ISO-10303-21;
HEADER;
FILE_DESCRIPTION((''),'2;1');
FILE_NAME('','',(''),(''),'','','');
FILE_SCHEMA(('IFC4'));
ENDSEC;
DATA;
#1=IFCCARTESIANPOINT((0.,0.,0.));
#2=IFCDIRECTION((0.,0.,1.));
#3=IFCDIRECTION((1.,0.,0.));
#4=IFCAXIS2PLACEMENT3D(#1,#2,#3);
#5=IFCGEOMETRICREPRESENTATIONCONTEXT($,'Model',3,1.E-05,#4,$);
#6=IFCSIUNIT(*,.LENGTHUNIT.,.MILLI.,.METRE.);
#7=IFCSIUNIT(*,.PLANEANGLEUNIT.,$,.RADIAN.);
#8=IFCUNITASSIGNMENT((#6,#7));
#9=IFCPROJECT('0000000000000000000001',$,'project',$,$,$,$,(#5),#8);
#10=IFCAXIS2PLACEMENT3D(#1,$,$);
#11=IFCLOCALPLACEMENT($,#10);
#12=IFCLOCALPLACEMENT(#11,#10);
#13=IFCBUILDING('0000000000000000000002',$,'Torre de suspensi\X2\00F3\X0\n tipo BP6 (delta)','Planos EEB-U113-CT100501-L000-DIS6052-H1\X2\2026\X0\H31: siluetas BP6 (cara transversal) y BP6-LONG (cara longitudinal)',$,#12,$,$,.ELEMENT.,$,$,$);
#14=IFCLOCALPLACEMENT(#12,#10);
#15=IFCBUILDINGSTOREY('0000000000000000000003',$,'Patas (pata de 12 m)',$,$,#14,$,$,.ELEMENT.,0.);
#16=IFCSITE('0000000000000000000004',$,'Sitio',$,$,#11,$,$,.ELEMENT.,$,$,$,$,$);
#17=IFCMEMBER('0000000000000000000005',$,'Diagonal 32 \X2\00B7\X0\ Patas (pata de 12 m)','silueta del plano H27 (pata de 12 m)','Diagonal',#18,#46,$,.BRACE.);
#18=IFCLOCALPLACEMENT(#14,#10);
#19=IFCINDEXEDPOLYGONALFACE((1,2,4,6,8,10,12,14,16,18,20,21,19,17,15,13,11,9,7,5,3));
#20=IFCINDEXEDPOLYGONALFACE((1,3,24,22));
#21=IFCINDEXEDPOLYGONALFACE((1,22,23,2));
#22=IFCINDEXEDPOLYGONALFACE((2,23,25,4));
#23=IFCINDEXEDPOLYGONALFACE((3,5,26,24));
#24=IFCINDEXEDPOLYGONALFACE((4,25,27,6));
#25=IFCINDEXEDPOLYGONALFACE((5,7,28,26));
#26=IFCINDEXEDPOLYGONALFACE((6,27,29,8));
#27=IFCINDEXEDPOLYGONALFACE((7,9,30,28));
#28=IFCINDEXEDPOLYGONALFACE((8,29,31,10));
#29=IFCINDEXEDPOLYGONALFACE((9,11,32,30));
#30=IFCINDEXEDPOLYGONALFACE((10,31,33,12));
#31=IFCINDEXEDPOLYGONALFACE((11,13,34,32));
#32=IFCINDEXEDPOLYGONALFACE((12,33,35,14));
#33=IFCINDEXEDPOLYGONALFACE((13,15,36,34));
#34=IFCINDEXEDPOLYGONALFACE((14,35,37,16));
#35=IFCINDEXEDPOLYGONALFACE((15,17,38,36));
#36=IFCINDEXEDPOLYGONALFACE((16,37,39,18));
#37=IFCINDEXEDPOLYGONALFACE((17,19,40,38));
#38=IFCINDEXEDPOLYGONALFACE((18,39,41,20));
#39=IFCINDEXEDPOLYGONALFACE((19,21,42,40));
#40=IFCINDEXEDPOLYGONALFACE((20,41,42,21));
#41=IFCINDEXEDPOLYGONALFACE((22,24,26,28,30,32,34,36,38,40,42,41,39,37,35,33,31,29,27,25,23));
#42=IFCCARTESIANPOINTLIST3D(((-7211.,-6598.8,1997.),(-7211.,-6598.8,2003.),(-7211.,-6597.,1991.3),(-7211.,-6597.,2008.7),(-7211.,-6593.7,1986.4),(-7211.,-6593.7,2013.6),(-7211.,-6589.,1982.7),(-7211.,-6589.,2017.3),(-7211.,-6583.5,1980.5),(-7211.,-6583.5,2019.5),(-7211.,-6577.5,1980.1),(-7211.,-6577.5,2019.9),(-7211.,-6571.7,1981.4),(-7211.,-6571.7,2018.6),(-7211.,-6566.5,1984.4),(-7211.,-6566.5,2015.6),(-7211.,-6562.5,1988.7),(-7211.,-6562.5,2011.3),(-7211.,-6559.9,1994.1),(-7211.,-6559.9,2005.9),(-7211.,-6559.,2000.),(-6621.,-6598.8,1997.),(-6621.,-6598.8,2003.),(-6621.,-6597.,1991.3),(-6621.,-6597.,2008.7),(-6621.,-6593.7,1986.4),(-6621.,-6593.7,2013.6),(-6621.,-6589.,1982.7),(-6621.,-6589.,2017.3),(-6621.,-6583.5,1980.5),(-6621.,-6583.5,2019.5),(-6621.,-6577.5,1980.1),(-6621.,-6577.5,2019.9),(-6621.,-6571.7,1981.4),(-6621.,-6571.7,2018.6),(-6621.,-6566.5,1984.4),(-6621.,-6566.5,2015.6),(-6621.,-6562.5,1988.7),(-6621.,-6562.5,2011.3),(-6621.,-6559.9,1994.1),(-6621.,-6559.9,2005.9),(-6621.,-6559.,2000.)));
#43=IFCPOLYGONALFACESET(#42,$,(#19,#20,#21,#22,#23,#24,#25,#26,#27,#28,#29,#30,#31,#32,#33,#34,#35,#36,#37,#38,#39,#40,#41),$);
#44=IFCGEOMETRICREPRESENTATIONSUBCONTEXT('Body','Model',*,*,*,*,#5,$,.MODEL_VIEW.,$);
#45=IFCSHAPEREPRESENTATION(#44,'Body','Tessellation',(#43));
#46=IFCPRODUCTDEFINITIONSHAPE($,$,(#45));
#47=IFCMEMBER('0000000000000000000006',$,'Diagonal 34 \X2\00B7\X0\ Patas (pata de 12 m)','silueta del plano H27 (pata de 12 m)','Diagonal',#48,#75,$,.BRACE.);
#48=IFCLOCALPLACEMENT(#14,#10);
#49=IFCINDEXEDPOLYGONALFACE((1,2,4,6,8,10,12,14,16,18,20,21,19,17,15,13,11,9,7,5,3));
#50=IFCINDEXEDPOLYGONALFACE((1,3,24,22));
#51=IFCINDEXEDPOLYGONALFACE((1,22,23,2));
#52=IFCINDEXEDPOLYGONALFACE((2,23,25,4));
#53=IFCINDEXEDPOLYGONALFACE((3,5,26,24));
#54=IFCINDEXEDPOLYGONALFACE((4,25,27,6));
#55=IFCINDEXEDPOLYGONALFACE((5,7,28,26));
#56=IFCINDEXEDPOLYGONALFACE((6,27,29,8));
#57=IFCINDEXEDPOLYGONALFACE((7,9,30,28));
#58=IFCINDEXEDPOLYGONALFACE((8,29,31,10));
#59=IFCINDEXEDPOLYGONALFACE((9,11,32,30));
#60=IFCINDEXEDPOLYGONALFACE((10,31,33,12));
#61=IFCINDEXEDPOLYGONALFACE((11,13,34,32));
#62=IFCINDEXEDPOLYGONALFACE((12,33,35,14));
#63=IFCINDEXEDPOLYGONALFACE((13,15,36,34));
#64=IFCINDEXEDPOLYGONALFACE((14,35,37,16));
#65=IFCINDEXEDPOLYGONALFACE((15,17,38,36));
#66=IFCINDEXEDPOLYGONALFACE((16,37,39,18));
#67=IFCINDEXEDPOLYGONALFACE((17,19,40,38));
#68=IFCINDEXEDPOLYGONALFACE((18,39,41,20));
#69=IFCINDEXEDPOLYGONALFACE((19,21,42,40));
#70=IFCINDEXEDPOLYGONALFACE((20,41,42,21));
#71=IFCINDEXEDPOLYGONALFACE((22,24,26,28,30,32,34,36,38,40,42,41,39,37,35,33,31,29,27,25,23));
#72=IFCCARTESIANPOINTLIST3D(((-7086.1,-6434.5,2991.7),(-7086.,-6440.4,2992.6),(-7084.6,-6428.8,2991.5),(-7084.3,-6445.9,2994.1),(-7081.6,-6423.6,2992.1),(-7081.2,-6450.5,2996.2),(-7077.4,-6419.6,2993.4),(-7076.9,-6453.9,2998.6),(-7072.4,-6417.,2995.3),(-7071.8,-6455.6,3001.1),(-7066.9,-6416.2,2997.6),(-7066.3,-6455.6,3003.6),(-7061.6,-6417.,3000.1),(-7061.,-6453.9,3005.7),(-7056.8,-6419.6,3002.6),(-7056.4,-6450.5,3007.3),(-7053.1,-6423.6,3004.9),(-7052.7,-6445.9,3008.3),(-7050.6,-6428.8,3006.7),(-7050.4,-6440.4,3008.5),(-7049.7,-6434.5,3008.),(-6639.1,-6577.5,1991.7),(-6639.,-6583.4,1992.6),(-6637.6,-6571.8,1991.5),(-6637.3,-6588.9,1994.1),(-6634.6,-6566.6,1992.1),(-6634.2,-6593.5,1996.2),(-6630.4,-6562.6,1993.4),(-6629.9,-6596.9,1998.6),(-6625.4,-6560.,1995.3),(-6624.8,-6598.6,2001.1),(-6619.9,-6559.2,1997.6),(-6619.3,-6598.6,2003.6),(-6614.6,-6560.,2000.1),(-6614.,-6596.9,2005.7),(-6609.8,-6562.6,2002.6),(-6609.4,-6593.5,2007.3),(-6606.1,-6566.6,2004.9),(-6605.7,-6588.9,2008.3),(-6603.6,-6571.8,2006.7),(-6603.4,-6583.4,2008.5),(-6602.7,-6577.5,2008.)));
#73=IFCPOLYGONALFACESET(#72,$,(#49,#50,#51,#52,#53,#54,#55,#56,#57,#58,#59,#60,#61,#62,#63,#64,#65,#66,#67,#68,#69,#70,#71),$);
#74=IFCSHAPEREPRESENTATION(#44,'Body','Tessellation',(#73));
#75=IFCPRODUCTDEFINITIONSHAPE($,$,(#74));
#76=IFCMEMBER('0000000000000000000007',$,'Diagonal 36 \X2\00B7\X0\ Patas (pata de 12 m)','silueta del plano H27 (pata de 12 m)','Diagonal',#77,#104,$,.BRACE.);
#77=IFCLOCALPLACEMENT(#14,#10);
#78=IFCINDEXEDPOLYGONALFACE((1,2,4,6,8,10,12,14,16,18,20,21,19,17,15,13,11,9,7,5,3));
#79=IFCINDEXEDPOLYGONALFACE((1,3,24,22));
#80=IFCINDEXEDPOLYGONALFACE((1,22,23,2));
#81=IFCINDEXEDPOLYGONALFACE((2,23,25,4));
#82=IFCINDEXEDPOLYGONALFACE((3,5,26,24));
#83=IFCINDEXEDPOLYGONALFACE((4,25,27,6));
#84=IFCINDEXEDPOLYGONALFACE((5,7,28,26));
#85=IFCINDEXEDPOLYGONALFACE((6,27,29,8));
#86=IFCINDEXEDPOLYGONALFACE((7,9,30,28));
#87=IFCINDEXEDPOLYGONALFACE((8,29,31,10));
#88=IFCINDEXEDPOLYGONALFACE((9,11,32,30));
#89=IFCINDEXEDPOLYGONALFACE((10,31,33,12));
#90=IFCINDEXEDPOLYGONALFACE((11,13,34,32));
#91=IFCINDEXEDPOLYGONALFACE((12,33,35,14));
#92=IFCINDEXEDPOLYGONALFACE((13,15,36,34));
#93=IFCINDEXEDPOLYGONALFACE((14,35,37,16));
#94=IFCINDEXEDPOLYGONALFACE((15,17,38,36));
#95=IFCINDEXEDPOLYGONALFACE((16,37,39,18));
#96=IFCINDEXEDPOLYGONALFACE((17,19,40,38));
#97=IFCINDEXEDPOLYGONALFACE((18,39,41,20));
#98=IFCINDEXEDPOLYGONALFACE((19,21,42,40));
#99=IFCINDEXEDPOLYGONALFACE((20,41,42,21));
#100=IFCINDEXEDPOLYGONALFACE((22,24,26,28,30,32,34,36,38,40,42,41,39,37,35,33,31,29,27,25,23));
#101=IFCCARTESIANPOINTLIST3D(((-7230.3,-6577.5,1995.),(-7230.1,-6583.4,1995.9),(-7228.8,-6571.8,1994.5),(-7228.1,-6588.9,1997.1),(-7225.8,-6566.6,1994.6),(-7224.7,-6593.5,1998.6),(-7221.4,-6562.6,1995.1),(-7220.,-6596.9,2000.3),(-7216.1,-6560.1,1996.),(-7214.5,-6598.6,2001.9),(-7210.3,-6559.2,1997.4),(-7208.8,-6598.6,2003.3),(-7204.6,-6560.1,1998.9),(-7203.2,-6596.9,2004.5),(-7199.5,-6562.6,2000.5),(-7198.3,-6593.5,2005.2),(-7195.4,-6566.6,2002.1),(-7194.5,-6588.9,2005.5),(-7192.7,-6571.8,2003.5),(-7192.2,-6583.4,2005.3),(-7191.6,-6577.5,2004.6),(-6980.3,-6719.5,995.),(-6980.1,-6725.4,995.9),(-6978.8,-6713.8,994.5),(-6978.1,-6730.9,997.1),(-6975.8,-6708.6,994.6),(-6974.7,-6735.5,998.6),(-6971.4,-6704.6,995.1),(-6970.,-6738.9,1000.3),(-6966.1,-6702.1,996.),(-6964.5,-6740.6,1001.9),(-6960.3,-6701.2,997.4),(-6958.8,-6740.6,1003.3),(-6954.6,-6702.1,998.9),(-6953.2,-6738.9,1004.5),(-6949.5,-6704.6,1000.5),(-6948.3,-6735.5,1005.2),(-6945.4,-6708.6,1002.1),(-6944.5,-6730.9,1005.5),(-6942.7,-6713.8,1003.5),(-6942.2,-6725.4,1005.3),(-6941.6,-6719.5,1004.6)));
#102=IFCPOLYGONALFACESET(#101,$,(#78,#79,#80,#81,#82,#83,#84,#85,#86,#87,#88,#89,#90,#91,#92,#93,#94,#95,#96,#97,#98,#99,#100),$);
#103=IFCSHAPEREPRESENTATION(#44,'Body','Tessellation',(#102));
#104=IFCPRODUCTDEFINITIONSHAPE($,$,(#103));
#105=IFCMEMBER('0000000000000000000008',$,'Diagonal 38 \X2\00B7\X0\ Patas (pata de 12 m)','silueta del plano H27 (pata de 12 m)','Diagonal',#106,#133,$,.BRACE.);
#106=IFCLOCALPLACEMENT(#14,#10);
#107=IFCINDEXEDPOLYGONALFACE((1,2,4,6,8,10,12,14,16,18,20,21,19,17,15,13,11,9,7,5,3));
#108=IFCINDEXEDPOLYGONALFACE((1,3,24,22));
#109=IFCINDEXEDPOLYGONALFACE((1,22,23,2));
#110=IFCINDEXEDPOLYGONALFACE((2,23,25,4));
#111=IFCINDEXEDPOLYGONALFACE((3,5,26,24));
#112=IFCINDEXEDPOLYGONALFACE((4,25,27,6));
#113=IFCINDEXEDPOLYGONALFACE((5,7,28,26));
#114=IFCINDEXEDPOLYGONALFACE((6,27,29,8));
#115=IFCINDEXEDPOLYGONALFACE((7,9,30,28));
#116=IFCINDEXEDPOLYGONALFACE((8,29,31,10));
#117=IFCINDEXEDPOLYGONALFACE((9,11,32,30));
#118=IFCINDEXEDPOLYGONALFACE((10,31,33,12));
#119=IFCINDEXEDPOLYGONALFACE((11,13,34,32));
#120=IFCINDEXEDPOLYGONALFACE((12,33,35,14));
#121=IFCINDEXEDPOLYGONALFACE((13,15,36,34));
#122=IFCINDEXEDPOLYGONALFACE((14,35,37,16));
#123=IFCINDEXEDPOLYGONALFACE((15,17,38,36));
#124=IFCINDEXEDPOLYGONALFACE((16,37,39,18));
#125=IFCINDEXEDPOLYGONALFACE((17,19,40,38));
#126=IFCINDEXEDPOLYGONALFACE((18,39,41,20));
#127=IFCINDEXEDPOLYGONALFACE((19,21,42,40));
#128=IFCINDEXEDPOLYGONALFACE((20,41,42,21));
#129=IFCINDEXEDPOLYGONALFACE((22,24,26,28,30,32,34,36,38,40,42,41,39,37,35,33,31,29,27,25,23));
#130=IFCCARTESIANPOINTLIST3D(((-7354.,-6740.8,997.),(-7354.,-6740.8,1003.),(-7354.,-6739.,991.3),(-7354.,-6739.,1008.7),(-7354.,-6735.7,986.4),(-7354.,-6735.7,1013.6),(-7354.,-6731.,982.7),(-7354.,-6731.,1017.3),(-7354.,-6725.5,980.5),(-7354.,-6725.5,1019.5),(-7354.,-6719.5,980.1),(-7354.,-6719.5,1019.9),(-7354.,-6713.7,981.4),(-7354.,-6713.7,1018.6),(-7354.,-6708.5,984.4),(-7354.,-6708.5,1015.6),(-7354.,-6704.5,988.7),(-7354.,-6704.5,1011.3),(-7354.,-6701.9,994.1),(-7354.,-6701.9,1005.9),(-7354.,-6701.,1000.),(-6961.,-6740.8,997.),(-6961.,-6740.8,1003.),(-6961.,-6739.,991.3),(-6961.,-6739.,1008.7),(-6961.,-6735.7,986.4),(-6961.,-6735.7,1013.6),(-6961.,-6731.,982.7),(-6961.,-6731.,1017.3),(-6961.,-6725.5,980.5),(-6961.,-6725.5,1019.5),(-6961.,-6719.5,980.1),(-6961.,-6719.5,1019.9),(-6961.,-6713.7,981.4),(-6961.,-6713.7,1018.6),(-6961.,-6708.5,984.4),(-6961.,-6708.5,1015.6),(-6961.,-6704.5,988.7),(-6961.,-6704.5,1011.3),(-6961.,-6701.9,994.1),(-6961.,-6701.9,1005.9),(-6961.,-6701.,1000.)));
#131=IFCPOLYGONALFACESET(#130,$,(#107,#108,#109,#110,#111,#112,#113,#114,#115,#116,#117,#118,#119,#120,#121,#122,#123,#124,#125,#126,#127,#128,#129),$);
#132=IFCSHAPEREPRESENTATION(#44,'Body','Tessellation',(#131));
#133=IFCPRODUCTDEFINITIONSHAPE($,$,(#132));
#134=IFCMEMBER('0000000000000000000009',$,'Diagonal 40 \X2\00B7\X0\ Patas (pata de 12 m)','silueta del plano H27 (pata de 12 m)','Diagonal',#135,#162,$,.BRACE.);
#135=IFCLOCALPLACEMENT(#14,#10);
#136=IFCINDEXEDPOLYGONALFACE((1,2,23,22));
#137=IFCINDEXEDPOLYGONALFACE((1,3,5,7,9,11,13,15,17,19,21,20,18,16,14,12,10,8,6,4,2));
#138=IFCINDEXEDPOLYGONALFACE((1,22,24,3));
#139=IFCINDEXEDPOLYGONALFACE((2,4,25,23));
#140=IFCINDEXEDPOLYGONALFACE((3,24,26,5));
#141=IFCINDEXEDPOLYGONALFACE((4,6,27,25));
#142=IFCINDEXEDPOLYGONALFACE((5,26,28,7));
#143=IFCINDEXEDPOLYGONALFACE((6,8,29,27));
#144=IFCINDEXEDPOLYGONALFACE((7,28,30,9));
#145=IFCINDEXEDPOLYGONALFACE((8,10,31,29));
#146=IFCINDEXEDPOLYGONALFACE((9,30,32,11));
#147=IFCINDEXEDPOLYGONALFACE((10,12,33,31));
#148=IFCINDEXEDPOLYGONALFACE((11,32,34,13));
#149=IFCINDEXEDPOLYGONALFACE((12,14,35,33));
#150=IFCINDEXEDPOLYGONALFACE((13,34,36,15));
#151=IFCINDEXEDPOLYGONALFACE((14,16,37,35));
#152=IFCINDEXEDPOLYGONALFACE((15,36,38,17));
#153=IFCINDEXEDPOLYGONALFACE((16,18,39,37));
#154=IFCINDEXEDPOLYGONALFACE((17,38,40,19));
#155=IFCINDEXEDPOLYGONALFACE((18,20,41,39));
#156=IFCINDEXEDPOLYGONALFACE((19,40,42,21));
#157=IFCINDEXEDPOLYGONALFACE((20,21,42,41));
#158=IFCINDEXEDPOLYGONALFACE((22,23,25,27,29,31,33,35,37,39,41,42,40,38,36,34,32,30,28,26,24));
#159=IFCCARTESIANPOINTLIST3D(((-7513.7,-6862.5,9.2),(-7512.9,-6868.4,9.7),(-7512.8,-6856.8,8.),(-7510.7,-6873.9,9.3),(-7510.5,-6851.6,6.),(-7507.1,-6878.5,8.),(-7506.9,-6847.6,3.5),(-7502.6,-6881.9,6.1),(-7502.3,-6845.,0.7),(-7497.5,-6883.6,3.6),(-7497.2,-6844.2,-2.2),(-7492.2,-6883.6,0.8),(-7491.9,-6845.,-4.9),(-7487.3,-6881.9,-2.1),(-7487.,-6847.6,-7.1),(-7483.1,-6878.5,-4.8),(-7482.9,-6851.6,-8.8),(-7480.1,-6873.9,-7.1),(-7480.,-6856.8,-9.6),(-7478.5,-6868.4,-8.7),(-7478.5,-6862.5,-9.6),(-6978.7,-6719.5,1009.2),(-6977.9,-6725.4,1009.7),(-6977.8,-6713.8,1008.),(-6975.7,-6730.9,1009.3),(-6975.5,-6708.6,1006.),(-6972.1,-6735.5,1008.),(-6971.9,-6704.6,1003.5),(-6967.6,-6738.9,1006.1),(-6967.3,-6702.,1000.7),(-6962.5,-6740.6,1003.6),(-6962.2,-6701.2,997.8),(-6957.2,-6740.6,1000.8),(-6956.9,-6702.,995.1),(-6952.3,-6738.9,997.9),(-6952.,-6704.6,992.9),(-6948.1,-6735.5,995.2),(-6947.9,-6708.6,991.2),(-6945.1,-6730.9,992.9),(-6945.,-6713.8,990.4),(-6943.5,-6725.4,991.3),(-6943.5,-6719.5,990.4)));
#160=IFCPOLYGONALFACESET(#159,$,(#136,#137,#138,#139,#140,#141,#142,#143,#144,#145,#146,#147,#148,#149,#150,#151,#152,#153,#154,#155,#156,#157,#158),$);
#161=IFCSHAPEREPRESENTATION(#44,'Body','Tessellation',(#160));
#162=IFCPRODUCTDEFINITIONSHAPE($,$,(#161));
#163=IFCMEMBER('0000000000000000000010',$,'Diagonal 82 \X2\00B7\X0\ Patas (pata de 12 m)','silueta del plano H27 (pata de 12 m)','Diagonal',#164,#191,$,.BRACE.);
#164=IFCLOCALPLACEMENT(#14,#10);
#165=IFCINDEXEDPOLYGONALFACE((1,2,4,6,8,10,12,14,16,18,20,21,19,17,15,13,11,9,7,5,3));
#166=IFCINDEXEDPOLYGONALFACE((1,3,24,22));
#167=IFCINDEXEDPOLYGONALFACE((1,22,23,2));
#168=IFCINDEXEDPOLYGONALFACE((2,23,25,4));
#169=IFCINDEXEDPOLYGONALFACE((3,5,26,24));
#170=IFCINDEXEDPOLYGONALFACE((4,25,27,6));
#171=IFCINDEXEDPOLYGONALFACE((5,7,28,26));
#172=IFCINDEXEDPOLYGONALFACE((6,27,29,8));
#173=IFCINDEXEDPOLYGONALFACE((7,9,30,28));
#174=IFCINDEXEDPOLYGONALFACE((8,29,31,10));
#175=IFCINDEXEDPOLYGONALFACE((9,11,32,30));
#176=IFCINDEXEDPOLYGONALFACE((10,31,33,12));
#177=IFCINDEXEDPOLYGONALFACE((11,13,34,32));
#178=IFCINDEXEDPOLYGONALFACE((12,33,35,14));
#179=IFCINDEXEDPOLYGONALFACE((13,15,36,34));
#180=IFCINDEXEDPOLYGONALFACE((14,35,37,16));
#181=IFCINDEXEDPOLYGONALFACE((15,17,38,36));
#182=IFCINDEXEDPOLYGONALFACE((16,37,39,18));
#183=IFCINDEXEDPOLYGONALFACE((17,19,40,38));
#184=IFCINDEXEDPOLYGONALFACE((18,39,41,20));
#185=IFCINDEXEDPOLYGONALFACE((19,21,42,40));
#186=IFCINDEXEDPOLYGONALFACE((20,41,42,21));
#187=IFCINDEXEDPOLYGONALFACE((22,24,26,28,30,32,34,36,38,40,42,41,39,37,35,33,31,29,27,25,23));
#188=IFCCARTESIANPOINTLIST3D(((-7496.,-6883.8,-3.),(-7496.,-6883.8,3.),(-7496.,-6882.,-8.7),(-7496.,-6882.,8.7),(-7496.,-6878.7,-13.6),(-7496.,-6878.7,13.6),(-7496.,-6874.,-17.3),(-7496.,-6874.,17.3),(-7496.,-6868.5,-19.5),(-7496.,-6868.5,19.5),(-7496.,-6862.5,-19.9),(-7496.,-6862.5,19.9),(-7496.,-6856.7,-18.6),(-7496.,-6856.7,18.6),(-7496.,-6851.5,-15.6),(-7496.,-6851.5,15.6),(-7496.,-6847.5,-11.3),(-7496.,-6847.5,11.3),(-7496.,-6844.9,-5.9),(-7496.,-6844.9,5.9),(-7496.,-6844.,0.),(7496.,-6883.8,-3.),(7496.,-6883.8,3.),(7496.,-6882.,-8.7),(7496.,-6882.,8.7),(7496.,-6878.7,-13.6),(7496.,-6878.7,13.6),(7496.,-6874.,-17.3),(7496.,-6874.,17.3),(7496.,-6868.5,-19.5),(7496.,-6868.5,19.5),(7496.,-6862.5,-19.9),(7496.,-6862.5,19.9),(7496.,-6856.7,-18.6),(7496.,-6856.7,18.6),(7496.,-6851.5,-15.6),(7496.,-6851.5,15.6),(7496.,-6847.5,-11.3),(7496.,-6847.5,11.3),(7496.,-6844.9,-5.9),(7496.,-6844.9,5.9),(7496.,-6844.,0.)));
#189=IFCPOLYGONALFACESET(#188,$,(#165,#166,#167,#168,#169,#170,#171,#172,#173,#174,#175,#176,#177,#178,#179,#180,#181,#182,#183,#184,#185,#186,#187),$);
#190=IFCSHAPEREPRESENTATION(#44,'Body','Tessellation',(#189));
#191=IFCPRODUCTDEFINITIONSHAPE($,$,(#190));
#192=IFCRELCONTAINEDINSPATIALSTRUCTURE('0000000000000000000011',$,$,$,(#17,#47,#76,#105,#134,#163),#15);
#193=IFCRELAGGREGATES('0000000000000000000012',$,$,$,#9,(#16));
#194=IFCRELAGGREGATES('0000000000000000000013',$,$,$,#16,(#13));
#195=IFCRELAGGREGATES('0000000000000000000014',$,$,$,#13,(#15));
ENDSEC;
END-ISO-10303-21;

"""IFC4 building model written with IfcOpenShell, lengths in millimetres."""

from ifc_helpers import new_model, si_unit, frame, origin, origin_with_axes, place, context, subcontext, project, spatial, circle, extrude, element, save


model = new_model("IFC4")

# Units and contexts
model_context = context("Model", 3, precision=1e-05, world=origin_with_axes())
body_context = subcontext(model_context, "Body", "Model", "MODEL_VIEW")
ifc_project = project(units=[si_unit("LENGTHUNIT", "METRE", prefix="MILLI"), si_unit("PLANEANGLEUNIT", "RADIAN")], contexts=[model_context])

# Site, building, storey
site_placement = place(None, origin())
site = spatial("IfcSite", under=ifc_project, at=site_placement, Name="Sitio", CompositionType="ELEMENT")
building_placement = place(site_placement, origin())
building = spatial("IfcBuilding", under=site, at=building_placement, Name="Torre de suspensión tipo BP6 (delta)", Description="Planos EEB-U113-CT100501-L000-DIS6052-H1…H31: siluetas BP6 (cara transversal) y BP6-LONG (cara longitudinal)", CompositionType="ELEMENT")
storey_placement = place(building_placement, origin())
storey = spatial("IfcBuildingStorey", under=building, at=storey_placement, Name="Patas (pata de 12 m)", CompositionType="ELEMENT", Elevation=0.0)

# Members
member_1_placement = place(storey_placement, frame((-7211.0, -6579.0, 2000.0), z_axis=(1.0, 0.0, 0.0), x_axis=(0.0, 1.0, 0.0)))
element("IfcMember", 1, at=member_1_placement, inside=storey, Name="Diagonal 32 · Patas (pata de 12 m)", Description="silueta del plano H27 (pata de 12 m)", ObjectType="Diagonal", PredefinedType="BRACE", context=body_context, shape_type="SweptSolid", body=[
    extrude(circle(Radius=20.0), None, (0.0, 0.0, 1.0), 590.0),
])
member_2_placement = place(storey_placement, frame((-6621.0, -6579.0, 2000.0), z_axis=(-0.404652, 0.129452, 0.905262), x_axis=(0.052828, 0.991586, -0.118183)))
element("IfcMember", 2, at=member_2_placement, inside=storey, Name="Diagonal 34 · Patas (pata de 12 m)", Description="silueta del plano H27 (pata de 12 m)", ObjectType="Diagonal", PredefinedType="BRACE", context=body_context, shape_type="SweptSolid", body=[
    extrude(circle(Radius=20.0), None, (0.0, 0.0, 1.0), 1104.7),
])
member_3_placement = place(storey_placement, frame((-6961.0, -6721.0, 1000.0), z_axis=(-0.240266, 0.136471, 0.961066), x_axis=(0.033099, 0.990644, -0.132397)))
element("IfcMember", 3, at=member_3_placement, inside=storey, Name="Diagonal 36 · Patas (pata de 12 m)", Description="silueta del plano H27 (pata de 12 m)", ObjectType="Diagonal", PredefinedType="BRACE", context=body_context, shape_type="SweptSolid", body=[
    extrude(circle(Radius=20.0), None, (0.0, 0.0, 1.0), 1040.5),
])
member_4_placement = place(storey_placement, frame((-7354.0, -6721.0, 1000.0), z_axis=(1.0, 0.0, 0.0), x_axis=(0.0, 1.0, 0.0)))
element("IfcMember", 4, at=member_4_placement, inside=storey, Name="Diagonal 38 · Patas (pata de 12 m)", Description="silueta del plano H27 (pata de 12 m)", ObjectType="Diagonal", PredefinedType="BRACE", context=body_context, shape_type="SweptSolid", body=[
    extrude(circle(Radius=20.0), None, (0.0, 0.0, 1.0), 393.0),
])
member_5_placement = place(storey_placement, frame((-7496.0, -6864.0, 0.0), z_axis=(0.468026, 0.125099, 0.874815), x_axis=(-0.059013, 0.992144, -0.110305)))
element("IfcMember", 5, at=member_5_placement, inside=storey, Name="Diagonal 40 · Patas (pata de 12 m)", Description="silueta del plano H27 (pata de 12 m)", ObjectType="Diagonal", PredefinedType="BRACE", context=body_context, shape_type="SweptSolid", body=[
    extrude(circle(Radius=20.0), None, (0.0, 0.0, 1.0), 1143.1),
])
member_6_placement = place(storey_placement, frame((-7496.0, -6864.0, 0.0), z_axis=(1.0, 0.0, 0.0), x_axis=(0.0, 1.0, 0.0)))
element("IfcMember", 6, at=member_6_placement, inside=storey, Name="Diagonal 82 · Patas (pata de 12 m)", Description="silueta del plano H27 (pata de 12 m)", ObjectType="Diagonal", PredefinedType="BRACE", context=body_context, shape_type="SweptSolid", body=[
    extrude(circle(Radius=20.0), None, (0.0, 0.0, 1.0), 14992.0),
])

save(model, "model.ifc")
